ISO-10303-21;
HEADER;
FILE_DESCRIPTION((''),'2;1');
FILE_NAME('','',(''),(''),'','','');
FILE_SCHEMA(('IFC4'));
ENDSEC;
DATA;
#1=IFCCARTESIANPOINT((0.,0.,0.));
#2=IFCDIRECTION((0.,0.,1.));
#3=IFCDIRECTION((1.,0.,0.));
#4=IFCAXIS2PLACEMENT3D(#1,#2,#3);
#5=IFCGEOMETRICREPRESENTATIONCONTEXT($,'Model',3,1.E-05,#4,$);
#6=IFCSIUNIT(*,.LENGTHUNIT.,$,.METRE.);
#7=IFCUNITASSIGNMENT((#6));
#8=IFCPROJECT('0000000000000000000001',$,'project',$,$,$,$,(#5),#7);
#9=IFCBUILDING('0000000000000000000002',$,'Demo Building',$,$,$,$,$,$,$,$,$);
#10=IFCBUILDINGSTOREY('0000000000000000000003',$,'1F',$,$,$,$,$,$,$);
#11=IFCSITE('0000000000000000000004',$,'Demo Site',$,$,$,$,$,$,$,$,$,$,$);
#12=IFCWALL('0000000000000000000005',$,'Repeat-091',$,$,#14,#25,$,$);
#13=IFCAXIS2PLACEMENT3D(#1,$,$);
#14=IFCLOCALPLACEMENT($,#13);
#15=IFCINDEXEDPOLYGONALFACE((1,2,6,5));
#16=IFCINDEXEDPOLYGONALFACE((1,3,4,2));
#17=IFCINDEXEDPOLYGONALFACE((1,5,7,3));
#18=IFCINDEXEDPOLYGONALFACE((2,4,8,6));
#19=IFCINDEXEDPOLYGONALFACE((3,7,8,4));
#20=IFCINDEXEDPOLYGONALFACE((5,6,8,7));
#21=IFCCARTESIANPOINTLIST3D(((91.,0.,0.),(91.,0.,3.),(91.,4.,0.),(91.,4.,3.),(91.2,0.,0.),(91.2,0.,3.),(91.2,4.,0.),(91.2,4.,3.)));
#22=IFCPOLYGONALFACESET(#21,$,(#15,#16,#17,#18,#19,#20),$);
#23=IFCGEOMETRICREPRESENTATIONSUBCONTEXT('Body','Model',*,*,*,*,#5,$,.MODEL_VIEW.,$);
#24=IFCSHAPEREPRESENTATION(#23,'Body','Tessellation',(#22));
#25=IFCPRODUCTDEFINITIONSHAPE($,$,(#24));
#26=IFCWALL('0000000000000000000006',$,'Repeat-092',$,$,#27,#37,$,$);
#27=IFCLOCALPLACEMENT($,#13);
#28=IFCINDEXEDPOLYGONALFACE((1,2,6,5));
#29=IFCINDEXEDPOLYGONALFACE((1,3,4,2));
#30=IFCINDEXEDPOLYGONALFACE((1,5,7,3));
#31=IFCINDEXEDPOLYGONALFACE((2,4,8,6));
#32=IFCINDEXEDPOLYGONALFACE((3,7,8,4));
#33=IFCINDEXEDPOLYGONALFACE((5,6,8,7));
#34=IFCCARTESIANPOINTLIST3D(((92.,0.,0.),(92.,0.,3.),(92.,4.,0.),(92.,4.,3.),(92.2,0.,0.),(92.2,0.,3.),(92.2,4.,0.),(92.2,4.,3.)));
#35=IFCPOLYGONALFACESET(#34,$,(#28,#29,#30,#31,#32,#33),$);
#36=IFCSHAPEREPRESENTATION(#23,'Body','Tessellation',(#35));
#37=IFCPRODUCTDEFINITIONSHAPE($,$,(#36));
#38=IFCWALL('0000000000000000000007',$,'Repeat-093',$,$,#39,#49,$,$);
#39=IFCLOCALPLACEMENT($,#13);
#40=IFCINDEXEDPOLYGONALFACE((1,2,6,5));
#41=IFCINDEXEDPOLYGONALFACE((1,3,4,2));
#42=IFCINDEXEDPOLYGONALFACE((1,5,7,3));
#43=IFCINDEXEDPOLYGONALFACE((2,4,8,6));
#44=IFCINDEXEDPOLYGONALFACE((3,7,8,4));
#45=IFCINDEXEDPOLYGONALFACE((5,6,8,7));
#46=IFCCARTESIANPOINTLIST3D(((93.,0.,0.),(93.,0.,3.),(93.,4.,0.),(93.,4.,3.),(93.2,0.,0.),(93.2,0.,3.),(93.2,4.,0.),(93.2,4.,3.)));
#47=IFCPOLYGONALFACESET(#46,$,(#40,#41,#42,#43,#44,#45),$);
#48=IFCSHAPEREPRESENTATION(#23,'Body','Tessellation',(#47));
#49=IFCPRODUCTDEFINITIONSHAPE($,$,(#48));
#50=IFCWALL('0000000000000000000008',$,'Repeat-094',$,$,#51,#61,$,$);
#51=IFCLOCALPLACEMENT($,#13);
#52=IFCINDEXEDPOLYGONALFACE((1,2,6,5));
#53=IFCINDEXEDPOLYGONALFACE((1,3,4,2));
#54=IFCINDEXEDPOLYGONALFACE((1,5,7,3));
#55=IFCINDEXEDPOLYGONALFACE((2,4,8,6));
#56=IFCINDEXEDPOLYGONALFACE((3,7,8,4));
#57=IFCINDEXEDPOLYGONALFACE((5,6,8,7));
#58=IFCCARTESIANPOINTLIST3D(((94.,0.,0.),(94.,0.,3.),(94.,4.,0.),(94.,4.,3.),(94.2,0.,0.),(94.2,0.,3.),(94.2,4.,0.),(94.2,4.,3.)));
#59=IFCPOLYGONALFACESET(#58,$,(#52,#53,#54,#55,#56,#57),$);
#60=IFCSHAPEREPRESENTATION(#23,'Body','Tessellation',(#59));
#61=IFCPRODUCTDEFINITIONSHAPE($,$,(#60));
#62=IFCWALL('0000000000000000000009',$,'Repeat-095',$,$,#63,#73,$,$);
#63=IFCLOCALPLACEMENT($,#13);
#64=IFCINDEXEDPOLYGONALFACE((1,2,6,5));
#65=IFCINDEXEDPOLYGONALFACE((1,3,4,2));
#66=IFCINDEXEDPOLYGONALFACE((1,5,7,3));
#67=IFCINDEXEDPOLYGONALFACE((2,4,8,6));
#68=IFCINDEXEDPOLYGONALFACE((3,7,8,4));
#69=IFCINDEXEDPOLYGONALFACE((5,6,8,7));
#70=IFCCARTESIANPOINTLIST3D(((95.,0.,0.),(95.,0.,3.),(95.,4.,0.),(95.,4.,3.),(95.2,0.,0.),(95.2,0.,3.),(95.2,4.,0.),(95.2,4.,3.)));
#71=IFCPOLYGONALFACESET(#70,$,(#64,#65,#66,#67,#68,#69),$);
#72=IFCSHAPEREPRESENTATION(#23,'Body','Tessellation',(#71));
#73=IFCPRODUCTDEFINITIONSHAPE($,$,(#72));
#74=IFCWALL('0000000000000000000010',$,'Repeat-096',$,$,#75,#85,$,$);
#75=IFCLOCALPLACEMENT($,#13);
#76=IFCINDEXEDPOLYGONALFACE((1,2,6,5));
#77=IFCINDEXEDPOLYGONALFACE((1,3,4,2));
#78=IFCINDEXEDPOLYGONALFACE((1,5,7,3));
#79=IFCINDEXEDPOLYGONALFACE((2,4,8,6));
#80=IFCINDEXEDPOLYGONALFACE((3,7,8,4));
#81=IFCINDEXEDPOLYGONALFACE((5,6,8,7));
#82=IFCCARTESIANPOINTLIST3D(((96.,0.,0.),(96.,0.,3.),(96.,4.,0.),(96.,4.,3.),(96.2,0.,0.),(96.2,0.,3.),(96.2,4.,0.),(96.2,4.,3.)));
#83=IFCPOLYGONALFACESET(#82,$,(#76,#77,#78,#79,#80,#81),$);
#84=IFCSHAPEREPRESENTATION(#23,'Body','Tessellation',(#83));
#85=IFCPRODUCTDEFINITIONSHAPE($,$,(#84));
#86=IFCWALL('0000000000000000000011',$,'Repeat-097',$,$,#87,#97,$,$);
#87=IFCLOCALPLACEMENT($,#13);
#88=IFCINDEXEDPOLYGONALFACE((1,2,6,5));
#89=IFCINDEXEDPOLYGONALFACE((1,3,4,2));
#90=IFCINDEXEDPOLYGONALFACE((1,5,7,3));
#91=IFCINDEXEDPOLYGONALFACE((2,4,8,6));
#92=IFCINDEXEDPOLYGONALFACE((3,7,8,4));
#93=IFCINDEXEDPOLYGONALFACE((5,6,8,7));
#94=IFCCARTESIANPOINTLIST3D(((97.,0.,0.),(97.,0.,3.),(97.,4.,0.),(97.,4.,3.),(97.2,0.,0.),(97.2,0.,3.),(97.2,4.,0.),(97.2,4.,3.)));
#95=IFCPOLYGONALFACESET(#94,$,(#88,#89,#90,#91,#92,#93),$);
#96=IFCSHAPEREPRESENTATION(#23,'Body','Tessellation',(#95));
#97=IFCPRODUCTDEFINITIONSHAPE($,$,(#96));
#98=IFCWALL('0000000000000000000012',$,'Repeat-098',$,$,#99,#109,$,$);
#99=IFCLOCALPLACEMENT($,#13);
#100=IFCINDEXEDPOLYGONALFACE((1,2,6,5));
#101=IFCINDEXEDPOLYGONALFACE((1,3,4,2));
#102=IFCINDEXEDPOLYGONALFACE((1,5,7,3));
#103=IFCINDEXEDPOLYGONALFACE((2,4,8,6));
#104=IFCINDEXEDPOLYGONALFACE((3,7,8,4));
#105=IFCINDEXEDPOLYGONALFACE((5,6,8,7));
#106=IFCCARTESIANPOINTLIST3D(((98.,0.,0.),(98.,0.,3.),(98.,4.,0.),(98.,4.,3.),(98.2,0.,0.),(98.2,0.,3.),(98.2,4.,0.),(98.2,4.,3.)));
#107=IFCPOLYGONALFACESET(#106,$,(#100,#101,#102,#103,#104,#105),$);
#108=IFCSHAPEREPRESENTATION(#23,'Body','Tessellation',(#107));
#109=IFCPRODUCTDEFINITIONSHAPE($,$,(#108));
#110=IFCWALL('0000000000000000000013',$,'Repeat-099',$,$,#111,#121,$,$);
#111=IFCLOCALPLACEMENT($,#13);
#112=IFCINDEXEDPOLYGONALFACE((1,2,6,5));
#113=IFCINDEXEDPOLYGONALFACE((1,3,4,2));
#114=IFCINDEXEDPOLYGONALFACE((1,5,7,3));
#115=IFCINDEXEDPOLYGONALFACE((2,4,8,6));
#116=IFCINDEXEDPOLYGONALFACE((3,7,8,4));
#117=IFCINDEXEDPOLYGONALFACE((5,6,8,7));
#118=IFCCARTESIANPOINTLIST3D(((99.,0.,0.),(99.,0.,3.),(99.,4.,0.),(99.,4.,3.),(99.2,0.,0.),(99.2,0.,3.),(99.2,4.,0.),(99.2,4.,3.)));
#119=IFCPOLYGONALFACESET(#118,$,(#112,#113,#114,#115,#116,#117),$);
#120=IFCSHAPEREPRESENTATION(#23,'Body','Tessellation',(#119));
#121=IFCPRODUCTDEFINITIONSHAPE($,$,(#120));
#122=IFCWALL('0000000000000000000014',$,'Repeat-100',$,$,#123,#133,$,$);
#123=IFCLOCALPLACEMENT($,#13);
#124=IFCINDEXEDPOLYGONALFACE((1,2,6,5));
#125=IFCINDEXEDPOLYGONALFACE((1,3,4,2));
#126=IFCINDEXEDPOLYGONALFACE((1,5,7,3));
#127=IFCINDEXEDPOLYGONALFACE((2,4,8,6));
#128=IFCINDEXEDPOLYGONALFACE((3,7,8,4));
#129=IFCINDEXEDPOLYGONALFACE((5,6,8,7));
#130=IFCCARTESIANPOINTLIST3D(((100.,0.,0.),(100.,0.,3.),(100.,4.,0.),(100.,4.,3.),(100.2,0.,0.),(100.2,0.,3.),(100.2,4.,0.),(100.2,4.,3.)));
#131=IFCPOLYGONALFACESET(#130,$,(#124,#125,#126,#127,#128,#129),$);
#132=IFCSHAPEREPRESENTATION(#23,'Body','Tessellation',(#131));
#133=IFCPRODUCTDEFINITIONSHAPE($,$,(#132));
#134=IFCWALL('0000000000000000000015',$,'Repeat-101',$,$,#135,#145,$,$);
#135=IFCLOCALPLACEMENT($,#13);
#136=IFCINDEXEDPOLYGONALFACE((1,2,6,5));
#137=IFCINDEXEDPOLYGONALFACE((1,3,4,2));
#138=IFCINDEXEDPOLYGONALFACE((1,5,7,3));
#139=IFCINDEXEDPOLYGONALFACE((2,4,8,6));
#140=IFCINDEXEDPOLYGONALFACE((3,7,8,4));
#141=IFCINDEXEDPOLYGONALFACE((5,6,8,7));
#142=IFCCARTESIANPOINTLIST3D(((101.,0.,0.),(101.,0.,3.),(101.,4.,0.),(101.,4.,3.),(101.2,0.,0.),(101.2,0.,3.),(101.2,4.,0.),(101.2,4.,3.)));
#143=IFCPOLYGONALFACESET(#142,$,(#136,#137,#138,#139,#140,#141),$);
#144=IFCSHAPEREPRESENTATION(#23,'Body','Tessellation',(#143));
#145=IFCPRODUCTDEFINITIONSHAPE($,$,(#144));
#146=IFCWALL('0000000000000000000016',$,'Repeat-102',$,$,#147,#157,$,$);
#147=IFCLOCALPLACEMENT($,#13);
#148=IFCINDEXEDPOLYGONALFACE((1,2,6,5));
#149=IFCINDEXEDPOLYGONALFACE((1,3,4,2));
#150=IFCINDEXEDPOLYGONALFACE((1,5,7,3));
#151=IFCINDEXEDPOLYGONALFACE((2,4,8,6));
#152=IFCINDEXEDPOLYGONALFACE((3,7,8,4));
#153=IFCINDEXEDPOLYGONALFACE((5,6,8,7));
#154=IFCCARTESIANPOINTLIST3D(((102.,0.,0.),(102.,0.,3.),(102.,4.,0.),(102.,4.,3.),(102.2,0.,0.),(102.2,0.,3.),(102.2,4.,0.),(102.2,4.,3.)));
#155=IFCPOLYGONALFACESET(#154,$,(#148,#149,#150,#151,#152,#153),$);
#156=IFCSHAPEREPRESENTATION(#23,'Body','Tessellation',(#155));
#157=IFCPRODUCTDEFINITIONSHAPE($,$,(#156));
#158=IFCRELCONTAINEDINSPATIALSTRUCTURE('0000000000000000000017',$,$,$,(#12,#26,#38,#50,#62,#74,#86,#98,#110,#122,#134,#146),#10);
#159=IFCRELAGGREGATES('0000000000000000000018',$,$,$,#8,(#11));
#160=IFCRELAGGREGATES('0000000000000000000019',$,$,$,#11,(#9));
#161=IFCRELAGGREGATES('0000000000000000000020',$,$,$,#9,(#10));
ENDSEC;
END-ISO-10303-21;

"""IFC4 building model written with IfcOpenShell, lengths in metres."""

from ifc_helpers import new_model, entity, si_unit, frame, origin_with_axes, place, context, subcontext, project, spatial, element, save


model = new_model("IFC4")

# Units and contexts
model_context = context("Model", 3, precision=1e-05, world=origin_with_axes())
body_context = subcontext(model_context, "Body", "Model", "MODEL_VIEW")
ifc_project = project(units=[si_unit("LENGTHUNIT", "METRE")], contexts=[model_context])

# Site, building, storey
site = spatial("IfcSite", under=ifc_project, Name="Demo Site")
building = spatial("IfcBuilding", under=site, Name="Demo Building")
storey = spatial("IfcBuildingStorey", under=building, Name="1F")

# Walls
for number, where, z_axis, x_axis, name in (
    (1, (91.0, 0.0, 0.0), (0.0, 0.0, 1.0), (1.0, 0.0, 0.0), "Repeat-091"),
    (2, (92.0, 0.0, 0.0), (0.0, 0.0, 1.0), (1.0, 0.0, 0.0), "Repeat-092"),
    (3, (93.0, 0.0, 0.0), (0.0, 0.0, 1.0), (1.0, 0.0, 0.0), "Repeat-093"),
    (4, (94.0, 0.0, 0.0), (0.0, 0.0, 1.0), (1.0, 0.0, 0.0), "Repeat-094"),
    (5, (95.0, 0.0, 0.0), (0.0, 0.0, 1.0), (1.0, 0.0, 0.0), "Repeat-095"),
    (6, (96.0, 0.0, 0.0), (0.0, 0.0, 1.0), (1.0, 0.0, 0.0), "Repeat-096"),
    (7, (97.0, 0.0, 0.0), (0.0, 0.0, 1.0), (1.0, 0.0, 0.0), "Repeat-097"),
    (8, (98.0, 0.0, 0.0), (0.0, 0.0, 1.0), (1.0, 0.0, 0.0), "Repeat-098"),
    (9, (99.0, 0.0, 0.0), (0.0, 0.0, 1.0), (1.0, 0.0, 0.0), "Repeat-099"),
    (10, (100.0, 0.0, 0.0), (0.0, 0.0, 1.0), (1.0, 0.0, 0.0), "Repeat-100"),
    (11, (101.0, 0.0, 0.0), (0.0, 0.0, 1.0), (1.0, 0.0, 0.0), "Repeat-101"),
    (12, (102.0, 0.0, 0.0), (0.0, 0.0, 1.0), (1.0, 0.0, 0.0), "Repeat-102"),
):
    element("IfcWall", number, at=place(None, frame(where, z_axis=z_axis, x_axis=x_axis)), inside=storey, Name=name, context=body_context, shape_type="CSG", body=[
        entity("IfcBlock", entity("IfcAxis2Placement3D", entity("IfcCartesianPoint", [0.0, 0.0, 0.0]), entity("IfcDirection", [0.0, 0.0, 1.0]), entity("IfcDirection", [1.0, 0.0, 0.0])), 0.2, 4.0, 3.0),
    ])

save(model, "model.ifc")
